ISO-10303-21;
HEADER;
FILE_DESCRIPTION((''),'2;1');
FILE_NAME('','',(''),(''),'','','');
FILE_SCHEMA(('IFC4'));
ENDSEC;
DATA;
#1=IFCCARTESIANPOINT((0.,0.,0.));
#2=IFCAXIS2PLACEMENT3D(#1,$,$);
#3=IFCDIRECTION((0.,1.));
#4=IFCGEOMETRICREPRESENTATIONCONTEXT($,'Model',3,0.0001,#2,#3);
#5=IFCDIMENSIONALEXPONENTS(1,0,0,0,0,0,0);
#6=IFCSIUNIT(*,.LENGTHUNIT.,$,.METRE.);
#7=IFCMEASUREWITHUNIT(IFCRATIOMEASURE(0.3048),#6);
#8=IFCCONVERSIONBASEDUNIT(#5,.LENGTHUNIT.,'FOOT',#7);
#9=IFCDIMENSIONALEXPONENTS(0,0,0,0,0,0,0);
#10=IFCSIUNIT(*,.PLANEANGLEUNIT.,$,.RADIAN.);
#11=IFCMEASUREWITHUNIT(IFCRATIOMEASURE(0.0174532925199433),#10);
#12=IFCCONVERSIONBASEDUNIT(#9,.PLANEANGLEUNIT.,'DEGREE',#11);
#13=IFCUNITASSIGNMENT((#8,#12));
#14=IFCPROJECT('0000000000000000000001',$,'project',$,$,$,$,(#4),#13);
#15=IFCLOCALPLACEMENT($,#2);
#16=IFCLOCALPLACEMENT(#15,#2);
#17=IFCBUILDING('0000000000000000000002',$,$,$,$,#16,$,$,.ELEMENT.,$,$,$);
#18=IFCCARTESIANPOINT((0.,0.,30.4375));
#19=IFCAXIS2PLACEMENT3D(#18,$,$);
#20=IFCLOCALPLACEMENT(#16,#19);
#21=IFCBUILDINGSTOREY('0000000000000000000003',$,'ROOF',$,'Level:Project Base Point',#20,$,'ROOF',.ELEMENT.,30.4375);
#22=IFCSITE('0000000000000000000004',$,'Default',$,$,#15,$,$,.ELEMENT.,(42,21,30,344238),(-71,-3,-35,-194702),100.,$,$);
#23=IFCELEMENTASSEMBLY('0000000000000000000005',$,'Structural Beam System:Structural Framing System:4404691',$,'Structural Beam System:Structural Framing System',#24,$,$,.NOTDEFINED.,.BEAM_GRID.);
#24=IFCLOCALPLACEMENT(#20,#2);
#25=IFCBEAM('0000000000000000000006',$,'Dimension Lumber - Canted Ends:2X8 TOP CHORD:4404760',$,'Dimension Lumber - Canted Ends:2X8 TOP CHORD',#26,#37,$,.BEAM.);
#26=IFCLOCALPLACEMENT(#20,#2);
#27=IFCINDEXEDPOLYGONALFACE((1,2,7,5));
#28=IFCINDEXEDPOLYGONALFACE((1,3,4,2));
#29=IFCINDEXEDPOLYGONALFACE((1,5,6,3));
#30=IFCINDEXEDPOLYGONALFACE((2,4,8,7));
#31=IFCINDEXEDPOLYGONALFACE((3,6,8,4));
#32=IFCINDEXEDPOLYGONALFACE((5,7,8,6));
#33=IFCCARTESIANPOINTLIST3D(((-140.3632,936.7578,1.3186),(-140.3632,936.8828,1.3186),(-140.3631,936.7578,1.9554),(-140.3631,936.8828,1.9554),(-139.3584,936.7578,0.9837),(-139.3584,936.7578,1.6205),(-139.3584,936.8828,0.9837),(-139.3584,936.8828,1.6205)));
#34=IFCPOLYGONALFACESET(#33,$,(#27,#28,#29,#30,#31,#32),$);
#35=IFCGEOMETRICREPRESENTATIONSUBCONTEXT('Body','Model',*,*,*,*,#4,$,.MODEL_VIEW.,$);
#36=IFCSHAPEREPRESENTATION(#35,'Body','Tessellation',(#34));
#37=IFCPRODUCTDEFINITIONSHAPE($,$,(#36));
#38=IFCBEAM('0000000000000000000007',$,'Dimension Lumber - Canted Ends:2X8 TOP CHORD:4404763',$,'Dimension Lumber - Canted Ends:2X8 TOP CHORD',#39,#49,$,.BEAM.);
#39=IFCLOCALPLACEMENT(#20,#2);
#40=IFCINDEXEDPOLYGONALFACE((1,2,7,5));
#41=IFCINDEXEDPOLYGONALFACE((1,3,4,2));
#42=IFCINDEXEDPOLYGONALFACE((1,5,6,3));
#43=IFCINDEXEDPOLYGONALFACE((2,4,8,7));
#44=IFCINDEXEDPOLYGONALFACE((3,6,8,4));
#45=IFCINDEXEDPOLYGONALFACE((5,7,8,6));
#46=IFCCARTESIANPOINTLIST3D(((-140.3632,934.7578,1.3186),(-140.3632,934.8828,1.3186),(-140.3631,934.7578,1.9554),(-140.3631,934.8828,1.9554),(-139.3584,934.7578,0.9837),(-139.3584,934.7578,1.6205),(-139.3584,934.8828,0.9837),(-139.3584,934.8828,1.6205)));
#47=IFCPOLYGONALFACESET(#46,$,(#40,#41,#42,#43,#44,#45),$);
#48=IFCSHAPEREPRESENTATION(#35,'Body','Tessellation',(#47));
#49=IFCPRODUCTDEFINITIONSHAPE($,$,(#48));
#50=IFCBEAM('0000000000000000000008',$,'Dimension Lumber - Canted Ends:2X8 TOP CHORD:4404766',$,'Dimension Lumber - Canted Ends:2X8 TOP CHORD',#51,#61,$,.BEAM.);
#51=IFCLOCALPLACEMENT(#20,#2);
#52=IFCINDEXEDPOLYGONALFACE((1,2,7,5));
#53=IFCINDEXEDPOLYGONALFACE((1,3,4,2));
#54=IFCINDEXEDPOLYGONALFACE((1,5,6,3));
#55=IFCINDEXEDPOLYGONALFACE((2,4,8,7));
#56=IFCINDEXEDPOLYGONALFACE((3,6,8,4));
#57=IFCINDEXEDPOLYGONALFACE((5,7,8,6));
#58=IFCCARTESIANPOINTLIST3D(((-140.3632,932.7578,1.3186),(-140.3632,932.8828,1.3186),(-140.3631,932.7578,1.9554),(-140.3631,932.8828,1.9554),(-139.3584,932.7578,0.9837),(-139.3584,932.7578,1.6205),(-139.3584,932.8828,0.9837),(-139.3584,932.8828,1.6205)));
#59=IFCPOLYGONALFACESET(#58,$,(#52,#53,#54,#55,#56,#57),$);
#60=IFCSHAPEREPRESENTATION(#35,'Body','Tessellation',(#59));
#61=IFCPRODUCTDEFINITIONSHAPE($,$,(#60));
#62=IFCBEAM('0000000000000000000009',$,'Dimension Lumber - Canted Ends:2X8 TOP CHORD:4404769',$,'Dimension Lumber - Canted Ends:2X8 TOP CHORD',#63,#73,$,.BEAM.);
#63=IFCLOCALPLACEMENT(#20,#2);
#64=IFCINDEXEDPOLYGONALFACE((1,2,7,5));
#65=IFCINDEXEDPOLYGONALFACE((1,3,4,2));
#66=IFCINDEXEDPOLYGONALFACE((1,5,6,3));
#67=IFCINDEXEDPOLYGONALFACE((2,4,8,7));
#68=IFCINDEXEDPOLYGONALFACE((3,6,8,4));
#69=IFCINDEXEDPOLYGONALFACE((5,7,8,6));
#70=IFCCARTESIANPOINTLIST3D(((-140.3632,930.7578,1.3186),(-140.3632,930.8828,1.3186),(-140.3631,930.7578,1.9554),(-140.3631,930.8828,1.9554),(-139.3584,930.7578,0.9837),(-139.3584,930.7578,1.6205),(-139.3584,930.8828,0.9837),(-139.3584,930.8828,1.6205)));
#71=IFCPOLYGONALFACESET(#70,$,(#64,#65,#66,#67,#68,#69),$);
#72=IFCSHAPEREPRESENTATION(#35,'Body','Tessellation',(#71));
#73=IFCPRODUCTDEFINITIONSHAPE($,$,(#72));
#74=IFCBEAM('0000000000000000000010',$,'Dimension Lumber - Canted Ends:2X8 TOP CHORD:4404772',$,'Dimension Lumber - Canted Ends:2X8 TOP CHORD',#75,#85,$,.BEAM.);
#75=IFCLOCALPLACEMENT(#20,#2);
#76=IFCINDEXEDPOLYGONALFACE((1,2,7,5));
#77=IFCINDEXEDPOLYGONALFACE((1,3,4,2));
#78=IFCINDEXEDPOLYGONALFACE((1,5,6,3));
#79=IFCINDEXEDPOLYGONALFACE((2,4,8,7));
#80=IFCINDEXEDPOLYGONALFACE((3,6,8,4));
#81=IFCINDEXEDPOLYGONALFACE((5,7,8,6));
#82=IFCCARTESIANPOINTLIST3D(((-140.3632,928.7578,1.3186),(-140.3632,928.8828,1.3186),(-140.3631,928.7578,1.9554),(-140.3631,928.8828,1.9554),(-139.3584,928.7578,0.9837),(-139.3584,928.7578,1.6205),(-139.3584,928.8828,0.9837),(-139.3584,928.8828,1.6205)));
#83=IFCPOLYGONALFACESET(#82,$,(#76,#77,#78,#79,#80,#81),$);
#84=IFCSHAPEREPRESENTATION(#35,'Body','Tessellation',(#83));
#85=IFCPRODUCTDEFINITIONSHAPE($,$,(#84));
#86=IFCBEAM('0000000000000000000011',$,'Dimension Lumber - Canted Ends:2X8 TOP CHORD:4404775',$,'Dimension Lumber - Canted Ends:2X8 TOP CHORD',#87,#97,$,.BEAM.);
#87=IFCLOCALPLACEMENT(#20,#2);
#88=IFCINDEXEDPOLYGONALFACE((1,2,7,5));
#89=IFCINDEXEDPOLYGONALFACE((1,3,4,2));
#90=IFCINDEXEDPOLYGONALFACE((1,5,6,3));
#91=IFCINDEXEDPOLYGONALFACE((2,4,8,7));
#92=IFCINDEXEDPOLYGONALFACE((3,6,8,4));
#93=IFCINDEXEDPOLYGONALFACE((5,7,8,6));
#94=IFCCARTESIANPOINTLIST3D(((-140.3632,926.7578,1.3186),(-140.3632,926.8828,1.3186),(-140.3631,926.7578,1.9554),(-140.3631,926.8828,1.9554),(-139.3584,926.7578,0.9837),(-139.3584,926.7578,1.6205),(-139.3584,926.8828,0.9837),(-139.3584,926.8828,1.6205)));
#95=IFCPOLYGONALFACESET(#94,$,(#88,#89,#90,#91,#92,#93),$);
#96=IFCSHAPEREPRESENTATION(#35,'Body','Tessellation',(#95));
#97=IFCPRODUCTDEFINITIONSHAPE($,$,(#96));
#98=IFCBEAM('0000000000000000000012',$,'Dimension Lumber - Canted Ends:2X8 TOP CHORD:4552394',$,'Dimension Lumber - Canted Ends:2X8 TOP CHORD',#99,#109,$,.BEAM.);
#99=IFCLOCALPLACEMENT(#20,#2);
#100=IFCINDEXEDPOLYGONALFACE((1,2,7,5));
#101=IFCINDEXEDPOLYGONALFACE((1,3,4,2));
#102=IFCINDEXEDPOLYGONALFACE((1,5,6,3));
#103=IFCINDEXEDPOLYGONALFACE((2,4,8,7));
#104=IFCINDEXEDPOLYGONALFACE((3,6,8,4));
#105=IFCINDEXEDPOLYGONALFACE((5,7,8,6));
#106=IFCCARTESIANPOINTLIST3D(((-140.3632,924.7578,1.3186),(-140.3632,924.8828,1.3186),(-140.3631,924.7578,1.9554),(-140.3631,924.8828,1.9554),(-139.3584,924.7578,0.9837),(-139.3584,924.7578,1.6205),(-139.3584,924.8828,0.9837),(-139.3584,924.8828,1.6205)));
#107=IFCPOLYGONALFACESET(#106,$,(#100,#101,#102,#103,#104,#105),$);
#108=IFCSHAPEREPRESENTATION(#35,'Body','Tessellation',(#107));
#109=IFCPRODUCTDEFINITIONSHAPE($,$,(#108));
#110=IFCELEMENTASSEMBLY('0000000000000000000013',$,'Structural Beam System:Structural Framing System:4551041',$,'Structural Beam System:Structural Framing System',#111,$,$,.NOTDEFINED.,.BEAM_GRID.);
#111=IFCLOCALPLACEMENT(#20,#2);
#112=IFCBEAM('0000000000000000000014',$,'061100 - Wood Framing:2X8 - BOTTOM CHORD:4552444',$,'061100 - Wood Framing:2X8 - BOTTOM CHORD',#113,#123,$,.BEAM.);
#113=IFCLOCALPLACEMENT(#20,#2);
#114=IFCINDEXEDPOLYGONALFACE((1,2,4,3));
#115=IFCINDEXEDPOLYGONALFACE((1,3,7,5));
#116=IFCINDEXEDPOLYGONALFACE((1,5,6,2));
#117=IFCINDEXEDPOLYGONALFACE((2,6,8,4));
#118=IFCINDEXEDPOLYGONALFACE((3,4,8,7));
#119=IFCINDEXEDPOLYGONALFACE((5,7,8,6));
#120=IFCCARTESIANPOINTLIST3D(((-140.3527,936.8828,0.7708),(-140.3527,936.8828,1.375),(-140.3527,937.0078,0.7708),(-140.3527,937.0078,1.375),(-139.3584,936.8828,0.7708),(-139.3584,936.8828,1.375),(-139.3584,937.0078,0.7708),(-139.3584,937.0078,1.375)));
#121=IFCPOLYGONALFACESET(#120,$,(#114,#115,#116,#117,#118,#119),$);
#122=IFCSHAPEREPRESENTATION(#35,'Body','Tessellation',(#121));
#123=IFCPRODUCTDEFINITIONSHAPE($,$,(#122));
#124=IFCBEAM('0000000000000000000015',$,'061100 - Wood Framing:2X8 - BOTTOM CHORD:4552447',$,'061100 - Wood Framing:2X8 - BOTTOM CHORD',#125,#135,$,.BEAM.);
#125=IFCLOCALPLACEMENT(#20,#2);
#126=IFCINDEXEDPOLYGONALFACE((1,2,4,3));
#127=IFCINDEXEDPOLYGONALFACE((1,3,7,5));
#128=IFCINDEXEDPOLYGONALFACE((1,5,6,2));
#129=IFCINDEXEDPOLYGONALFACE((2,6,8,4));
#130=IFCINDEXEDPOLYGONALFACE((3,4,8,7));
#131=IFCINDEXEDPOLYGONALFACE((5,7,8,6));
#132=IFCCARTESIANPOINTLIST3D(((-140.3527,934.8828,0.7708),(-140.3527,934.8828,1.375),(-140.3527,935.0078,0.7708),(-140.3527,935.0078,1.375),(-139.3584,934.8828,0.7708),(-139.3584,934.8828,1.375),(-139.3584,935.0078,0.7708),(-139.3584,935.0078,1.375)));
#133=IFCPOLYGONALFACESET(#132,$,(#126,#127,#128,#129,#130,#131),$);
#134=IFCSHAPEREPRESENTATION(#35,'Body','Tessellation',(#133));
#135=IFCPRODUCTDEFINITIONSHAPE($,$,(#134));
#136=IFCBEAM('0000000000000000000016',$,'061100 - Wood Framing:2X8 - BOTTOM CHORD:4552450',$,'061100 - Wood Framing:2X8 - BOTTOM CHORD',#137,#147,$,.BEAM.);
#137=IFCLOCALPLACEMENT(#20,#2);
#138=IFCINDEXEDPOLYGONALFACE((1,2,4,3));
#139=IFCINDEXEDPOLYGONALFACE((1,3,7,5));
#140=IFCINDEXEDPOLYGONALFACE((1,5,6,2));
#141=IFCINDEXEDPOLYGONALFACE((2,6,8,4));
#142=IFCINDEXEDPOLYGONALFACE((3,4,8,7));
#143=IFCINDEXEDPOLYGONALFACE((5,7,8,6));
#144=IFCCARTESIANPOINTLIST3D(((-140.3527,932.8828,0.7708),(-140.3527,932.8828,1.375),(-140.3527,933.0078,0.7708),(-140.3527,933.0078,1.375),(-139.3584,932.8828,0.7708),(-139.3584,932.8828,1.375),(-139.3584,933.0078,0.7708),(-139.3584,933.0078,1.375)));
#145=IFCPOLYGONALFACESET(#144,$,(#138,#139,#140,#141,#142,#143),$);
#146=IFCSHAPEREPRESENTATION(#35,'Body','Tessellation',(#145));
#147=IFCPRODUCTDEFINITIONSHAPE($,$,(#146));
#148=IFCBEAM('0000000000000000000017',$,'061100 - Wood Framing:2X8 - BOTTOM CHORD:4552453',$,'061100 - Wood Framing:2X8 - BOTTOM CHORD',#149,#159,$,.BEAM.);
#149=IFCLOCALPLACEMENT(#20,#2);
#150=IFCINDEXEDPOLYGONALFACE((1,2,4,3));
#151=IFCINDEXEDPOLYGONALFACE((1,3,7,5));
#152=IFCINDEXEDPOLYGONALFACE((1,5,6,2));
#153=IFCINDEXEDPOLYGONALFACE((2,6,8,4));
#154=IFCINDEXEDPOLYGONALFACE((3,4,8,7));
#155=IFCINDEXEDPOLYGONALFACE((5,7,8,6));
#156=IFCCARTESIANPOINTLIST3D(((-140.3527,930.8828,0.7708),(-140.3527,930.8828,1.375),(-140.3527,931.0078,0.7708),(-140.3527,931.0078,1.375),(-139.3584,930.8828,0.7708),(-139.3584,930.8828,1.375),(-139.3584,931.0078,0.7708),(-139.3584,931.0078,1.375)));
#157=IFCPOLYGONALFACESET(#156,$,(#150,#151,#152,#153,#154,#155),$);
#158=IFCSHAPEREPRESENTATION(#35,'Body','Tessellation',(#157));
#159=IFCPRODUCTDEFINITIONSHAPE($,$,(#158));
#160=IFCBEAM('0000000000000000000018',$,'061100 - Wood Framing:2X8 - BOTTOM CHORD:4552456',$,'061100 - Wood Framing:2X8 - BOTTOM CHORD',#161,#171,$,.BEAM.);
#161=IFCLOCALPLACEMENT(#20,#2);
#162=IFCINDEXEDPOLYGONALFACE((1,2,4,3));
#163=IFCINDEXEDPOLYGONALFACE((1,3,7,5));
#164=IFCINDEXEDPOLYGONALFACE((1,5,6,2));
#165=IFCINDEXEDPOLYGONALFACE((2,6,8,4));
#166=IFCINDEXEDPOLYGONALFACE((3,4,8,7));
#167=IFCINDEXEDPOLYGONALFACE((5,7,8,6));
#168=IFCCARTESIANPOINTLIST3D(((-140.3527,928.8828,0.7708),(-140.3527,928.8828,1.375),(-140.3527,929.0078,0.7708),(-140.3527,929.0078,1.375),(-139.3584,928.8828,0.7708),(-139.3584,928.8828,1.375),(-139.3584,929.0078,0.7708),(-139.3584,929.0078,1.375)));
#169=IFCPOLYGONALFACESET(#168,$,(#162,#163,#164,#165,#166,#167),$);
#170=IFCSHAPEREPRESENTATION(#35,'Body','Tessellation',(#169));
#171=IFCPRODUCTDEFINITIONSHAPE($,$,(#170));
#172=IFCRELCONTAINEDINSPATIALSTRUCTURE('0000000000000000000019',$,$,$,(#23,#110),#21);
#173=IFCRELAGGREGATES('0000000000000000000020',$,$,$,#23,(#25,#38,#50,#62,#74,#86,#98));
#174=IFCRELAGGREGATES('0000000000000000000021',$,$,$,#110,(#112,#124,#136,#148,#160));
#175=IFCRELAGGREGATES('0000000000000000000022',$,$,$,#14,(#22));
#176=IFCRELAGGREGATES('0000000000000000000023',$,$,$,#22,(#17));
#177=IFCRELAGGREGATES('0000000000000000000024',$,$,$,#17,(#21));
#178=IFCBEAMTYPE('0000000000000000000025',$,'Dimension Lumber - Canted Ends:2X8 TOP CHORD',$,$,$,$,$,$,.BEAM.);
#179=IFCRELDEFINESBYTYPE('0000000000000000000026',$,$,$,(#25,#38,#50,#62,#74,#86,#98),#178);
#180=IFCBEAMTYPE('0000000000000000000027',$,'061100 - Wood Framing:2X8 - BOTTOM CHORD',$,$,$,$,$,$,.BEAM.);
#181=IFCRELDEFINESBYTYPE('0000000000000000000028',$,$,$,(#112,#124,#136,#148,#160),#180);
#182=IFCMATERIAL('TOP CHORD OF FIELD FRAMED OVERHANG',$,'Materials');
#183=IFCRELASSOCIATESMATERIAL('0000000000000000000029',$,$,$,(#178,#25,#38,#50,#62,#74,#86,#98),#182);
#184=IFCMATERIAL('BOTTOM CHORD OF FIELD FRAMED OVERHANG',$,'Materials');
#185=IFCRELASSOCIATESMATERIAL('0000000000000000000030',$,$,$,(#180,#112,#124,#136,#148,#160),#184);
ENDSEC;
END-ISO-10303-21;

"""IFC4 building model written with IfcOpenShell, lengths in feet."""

from ifc_helpers import new_model, entity, si_unit, converted_unit, direction, frame, frame_2d, origin, origin_2d_with_axis, place, context, subcontext, project, spatial, rectangle, extrude, clip, halfspace, source, transform, mapped, material, material_profile, profile_set, profile_usage, type_object, type_shapes, element, aggregate, save


model = new_model("IFC4")

# Units and contexts
model_context = context("Model", 3, precision=0.0001, world=origin(), true_north=direction((0.0, 1.0)))
body_context = subcontext(model_context, "Body", "Model", "MODEL_VIEW")
ifc_project = project(units=[converted_unit("LENGTHUNIT", "FOOT", entity("IfcRatioMeasure", 0.3048), si_unit("LENGTHUNIT", "METRE"), dimensions=[1, 0, 0, 0, 0, 0, 0]), converted_unit("PLANEANGLEUNIT", "DEGREE", entity("IfcRatioMeasure", 0.0174532925199433), si_unit("PLANEANGLEUNIT", "RADIAN"), dimensions=[0, 0, 0, 0, 0, 0, 0])], contexts=[model_context])

# Site, building, storey
site_placement = place(None, origin())
site = spatial("IfcSite", under=ifc_project, at=site_placement, Name="Default", CompositionType="ELEMENT", RefLatitude=(42, 21, 30, 344238), RefLongitude=(-71, -3, -35, -194702), RefElevation=100.0)
building_placement = place(site_placement, origin())
building = spatial("IfcBuilding", under=site, at=building_placement, CompositionType="ELEMENT")
storey_placement = place(building_placement, frame((0.0, 0.0, 30.4375)))
storey = spatial("IfcBuildingStorey", under=building, at=storey_placement, Name="ROOF", ObjectType="Level:Project Base Point", LongName="ROOF", CompositionType="ELEMENT", Elevation=30.4375)

# Element assemblies, beams
ifc_material_1 = material(Name="BOTTOM CHORD OF FIELD FRAMED OVERHANG", Category="Materials")
ifc_material_profile_1 = material_profile(ifc_material_1, rectangle(XDim=0.6042, YDim=0.125, at=origin_2d_with_axis()), Name="2X8 - BOTTOM CHORD")
ifc_profile_set_1 = profile_set([ifc_material_profile_1], Name="2X8 - BOTTOM CHORD")
ifc_material_2 = material(Name="TOP CHORD OF FIELD FRAMED OVERHANG", Category="Materials")
ifc_material_profile_2 = material_profile(ifc_material_2, rectangle(XDim=0.6042, YDim=0.125, at=origin_2d_with_axis()), Name="2X8 TOP CHORD")
ifc_profile_set_2 = profile_set([ifc_material_profile_2], Name="2X8 TOP CHORD")
assembly_1_placement = place(storey_placement, origin())
assembly_1 = element("IfcElementAssembly", 1, at=assembly_1_placement, inside=storey, Name="Structural Beam System:Structural Framing System:4404691", ObjectType="Structural Beam System:Structural Framing System", AssemblyPlace="NOTDEFINED", PredefinedType="BEAM_GRID")
beam_type_1 = type_object("IfcBeamType", Name="Dimension Lumber - Canted Ends:2X8 TOP CHORD", PredefinedType="BEAM", material=ifc_profile_set_2)
shared_shape_1 = source(origin(), body_context, "Body", "Clipping", [
    clip(clip(extrude(rectangle(XDim=0.6042, YDim=0.125, at=frame_2d((0.0, 0.0), x_axis=(1.0, 0.0))), frame((-0.5296, 0.0, 0.0), z_axis=(1.0, 0.0, 0.0), x_axis=(0.0, 0.0, -1.0)), (0.0, 0.0, 1.0), 1.2605), halfspace(frame((0.5296, -0.0625, -0.3021), z_axis=(0.948711, 0.0, -0.316146), x_axis=(0.0, 1.0, 0.0)), False)), halfspace(frame((-0.3282, -0.0625, 0.3021), z_axis=(-0.948711, 0.0, 0.316146), x_axis=(0.0, 1.0, 0.0)), False)),
])
type_shapes(beam_type_1, [shared_shape_1])
ifc_profile_usage_1 = profile_usage(ifc_profile_set_2, cardinal=8)
beam_1_placement = place(assembly_1_placement, frame((-139.7653, 936.8203, 1.4377), z_axis=(0.316228, 0.0, 0.948683), x_axis=(-0.948683, 0.0, 0.316228)))
beam_1 = element("IfcBeam", 2, at=beam_1_placement, type_object=beam_type_1, material=ifc_profile_usage_1, Name="Dimension Lumber - Canted Ends:2X8 TOP CHORD:4404760", ObjectType="Dimension Lumber - Canted Ends:2X8 TOP CHORD", PredefinedType="BEAM", context=body_context, shape_type="MappedRepresentation", body=[
    mapped(shared_shape_1, transform((0.0, 0.0, 0.0), scale=1.0)),
])
ifc_profile_usage_2 = profile_usage(ifc_profile_set_2, cardinal=8)
beam_2_placement = place(assembly_1_placement, frame((-139.7653, 934.8203, 1.4377), z_axis=(0.316228, 0.0, 0.948683), x_axis=(-0.948683, 0.0, 0.316228)))
beam_2 = element("IfcBeam", 3, at=beam_2_placement, type_object=beam_type_1, material=ifc_profile_usage_2, Name="Dimension Lumber - Canted Ends:2X8 TOP CHORD:4404763", ObjectType="Dimension Lumber - Canted Ends:2X8 TOP CHORD", PredefinedType="BEAM", context=body_context, shape_type="MappedRepresentation", body=[
    mapped(shared_shape_1, transform((0.0, 0.0, 0.0), scale=1.0)),
])
ifc_profile_usage_3 = profile_usage(ifc_profile_set_2, cardinal=8)
beam_3_placement = place(assembly_1_placement, frame((-139.7653, 932.8203, 1.4377), z_axis=(0.316228, 0.0, 0.948683), x_axis=(-0.948683, 0.0, 0.316228)))
beam_3 = element("IfcBeam", 4, at=beam_3_placement, type_object=beam_type_1, material=ifc_profile_usage_3, Name="Dimension Lumber - Canted Ends:2X8 TOP CHORD:4404766", ObjectType="Dimension Lumber - Canted Ends:2X8 TOP CHORD", PredefinedType="BEAM", context=body_context, shape_type="MappedRepresentation", body=[
    mapped(shared_shape_1, transform((0.0, 0.0, 0.0), scale=1.0)),
])
ifc_profile_usage_4 = profile_usage(ifc_profile_set_2, cardinal=8)
beam_4_placement = place(assembly_1_placement, frame((-139.7653, 930.8203, 1.4377), z_axis=(0.316228, 0.0, 0.948683), x_axis=(-0.948683, 0.0, 0.316228)))
beam_4 = element("IfcBeam", 5, at=beam_4_placement, type_object=beam_type_1, material=ifc_profile_usage_4, Name="Dimension Lumber - Canted Ends:2X8 TOP CHORD:4404769", ObjectType="Dimension Lumber - Canted Ends:2X8 TOP CHORD", PredefinedType="BEAM", context=body_context, shape_type="MappedRepresentation", body=[
    mapped(shared_shape_1, transform((0.0, 0.0, 0.0), scale=1.0)),
])
ifc_profile_usage_5 = profile_usage(ifc_profile_set_2, cardinal=8)
beam_5_placement = place(assembly_1_placement, frame((-139.7653, 928.8203, 1.4377), z_axis=(0.316228, 0.0, 0.948683), x_axis=(-0.948683, 0.0, 0.316228)))
beam_5 = element("IfcBeam", 6, at=beam_5_placement, type_object=beam_type_1, material=ifc_profile_usage_5, Name="Dimension Lumber - Canted Ends:2X8 TOP CHORD:4404772", ObjectType="Dimension Lumber - Canted Ends:2X8 TOP CHORD", PredefinedType="BEAM", context=body_context, shape_type="MappedRepresentation", body=[
    mapped(shared_shape_1, transform((0.0, 0.0, 0.0), scale=1.0)),
])
ifc_profile_usage_6 = profile_usage(ifc_profile_set_2, cardinal=8)
beam_6_placement = place(assembly_1_placement, frame((-139.7653, 926.8203, 1.4377), z_axis=(0.316228, 0.0, 0.948683), x_axis=(-0.948683, 0.0, 0.316228)))
beam_6 = element("IfcBeam", 7, at=beam_6_placement, type_object=beam_type_1, material=ifc_profile_usage_6, Name="Dimension Lumber - Canted Ends:2X8 TOP CHORD:4404775", ObjectType="Dimension Lumber - Canted Ends:2X8 TOP CHORD", PredefinedType="BEAM", context=body_context, shape_type="MappedRepresentation", body=[
    mapped(shared_shape_1, transform((0.0, 0.0, 0.0), scale=1.0)),
])
ifc_profile_usage_7 = profile_usage(ifc_profile_set_2, cardinal=8)
beam_7_placement = place(assembly_1_placement, frame((-139.7653, 924.8203, 1.4377), z_axis=(0.316228, 0.0, 0.948683), x_axis=(-0.948683, 0.0, 0.316228)))
beam_7 = element("IfcBeam", 8, at=beam_7_placement, type_object=beam_type_1, material=ifc_profile_usage_7, Name="Dimension Lumber - Canted Ends:2X8 TOP CHORD:4552394", ObjectType="Dimension Lumber - Canted Ends:2X8 TOP CHORD", PredefinedType="BEAM", context=body_context, shape_type="MappedRepresentation", body=[
    mapped(shared_shape_1, transform((0.0, 0.0, 0.0), scale=1.0)),
])
aggregate(assembly_1, [beam_1, beam_2, beam_3, beam_4, beam_5, beam_6, beam_7])
assembly_2_placement = place(storey_placement, origin())
assembly_2 = element("IfcElementAssembly", 9, at=assembly_2_placement, inside=storey, Name="Structural Beam System:Structural Framing System:4551041", ObjectType="Structural Beam System:Structural Framing System", AssemblyPlace="NOTDEFINED", PredefinedType="BEAM_GRID")
ifc_profile_usage_8 = profile_usage(ifc_profile_set_1, cardinal=8)
beam_type_2 = type_object("IfcBeamType", Name="061100 - Wood Framing:2X8 - BOTTOM CHORD", PredefinedType="BEAM", material=ifc_profile_set_1)
shared_shape_2 = source(origin(), body_context, "Body", "SweptSolid", [
    extrude(rectangle(XDim=0.6042, YDim=0.125, at=origin_2d_with_axis()), frame((-0.4972, 0.0, 0.0), z_axis=(1.0, 0.0, 0.0), x_axis=(0.0, 0.0, -1.0)), (0.0, 0.0, 1.0), 0.9944),
])
type_shapes(beam_type_2, [shared_shape_2])
beam_8_placement = place(assembly_2_placement, frame((-139.8556, 936.9453, 1.0729)))
beam_8 = element("IfcBeam", 10, at=beam_8_placement, type_object=beam_type_2, material=ifc_profile_usage_8, Name="061100 - Wood Framing:2X8 - BOTTOM CHORD:4552444", ObjectType="061100 - Wood Framing:2X8 - BOTTOM CHORD", PredefinedType="BEAM", context=body_context, shape_type="MappedRepresentation", body=[
    mapped(shared_shape_2, transform((0.0, 0.0, 0.0), scale=1.0)),
])
ifc_profile_usage_9 = profile_usage(ifc_profile_set_1, cardinal=8)
beam_9_placement = place(assembly_2_placement, frame((-139.8556, 934.9453, 1.0729)))
beam_9 = element("IfcBeam", 11, at=beam_9_placement, type_object=beam_type_2, material=ifc_profile_usage_9, Name="061100 - Wood Framing:2X8 - BOTTOM CHORD:4552447", ObjectType="061100 - Wood Framing:2X8 - BOTTOM CHORD", PredefinedType="BEAM", context=body_context, shape_type="MappedRepresentation", body=[
    mapped(shared_shape_2, transform((0.0, 0.0, 0.0), scale=1.0)),
])
ifc_profile_usage_10 = profile_usage(ifc_profile_set_1, cardinal=8)
beam_10_placement = place(assembly_2_placement, frame((-139.8556, 932.9453, 1.0729)))
beam_10 = element("IfcBeam", 12, at=beam_10_placement, type_object=beam_type_2, material=ifc_profile_usage_10, Name="061100 - Wood Framing:2X8 - BOTTOM CHORD:4552450", ObjectType="061100 - Wood Framing:2X8 - BOTTOM CHORD", PredefinedType="BEAM", context=body_context, shape_type="MappedRepresentation", body=[
    mapped(shared_shape_2, transform((0.0, 0.0, 0.0), scale=1.0)),
])
ifc_profile_usage_11 = profile_usage(ifc_profile_set_1, cardinal=8)
beam_11_placement = place(assembly_2_placement, frame((-139.8556, 930.9453, 1.0729)))
beam_11 = element("IfcBeam", 13, at=beam_11_placement, type_object=beam_type_2, material=ifc_profile_usage_11, Name="061100 - Wood Framing:2X8 - BOTTOM CHORD:4552453", ObjectType="061100 - Wood Framing:2X8 - BOTTOM CHORD", PredefinedType="BEAM", context=body_context, shape_type="MappedRepresentation", body=[
    mapped(shared_shape_2, transform((0.0, 0.0, 0.0), scale=1.0)),
])
ifc_profile_usage_12 = profile_usage(ifc_profile_set_1, cardinal=8)
beam_12_placement = place(assembly_2_placement, frame((-139.8556, 928.9453, 1.0729)))
beam_12 = element("IfcBeam", 14, at=beam_12_placement, type_object=beam_type_2, material=ifc_profile_usage_12, Name="061100 - Wood Framing:2X8 - BOTTOM CHORD:4552456", ObjectType="061100 - Wood Framing:2X8 - BOTTOM CHORD", PredefinedType="BEAM", context=body_context, shape_type="MappedRepresentation", body=[
    mapped(shared_shape_2, transform((0.0, 0.0, 0.0), scale=1.0)),
])
aggregate(assembly_2, [beam_8, beam_9, beam_10, beam_11, beam_12])

save(model, "model.ifc")
